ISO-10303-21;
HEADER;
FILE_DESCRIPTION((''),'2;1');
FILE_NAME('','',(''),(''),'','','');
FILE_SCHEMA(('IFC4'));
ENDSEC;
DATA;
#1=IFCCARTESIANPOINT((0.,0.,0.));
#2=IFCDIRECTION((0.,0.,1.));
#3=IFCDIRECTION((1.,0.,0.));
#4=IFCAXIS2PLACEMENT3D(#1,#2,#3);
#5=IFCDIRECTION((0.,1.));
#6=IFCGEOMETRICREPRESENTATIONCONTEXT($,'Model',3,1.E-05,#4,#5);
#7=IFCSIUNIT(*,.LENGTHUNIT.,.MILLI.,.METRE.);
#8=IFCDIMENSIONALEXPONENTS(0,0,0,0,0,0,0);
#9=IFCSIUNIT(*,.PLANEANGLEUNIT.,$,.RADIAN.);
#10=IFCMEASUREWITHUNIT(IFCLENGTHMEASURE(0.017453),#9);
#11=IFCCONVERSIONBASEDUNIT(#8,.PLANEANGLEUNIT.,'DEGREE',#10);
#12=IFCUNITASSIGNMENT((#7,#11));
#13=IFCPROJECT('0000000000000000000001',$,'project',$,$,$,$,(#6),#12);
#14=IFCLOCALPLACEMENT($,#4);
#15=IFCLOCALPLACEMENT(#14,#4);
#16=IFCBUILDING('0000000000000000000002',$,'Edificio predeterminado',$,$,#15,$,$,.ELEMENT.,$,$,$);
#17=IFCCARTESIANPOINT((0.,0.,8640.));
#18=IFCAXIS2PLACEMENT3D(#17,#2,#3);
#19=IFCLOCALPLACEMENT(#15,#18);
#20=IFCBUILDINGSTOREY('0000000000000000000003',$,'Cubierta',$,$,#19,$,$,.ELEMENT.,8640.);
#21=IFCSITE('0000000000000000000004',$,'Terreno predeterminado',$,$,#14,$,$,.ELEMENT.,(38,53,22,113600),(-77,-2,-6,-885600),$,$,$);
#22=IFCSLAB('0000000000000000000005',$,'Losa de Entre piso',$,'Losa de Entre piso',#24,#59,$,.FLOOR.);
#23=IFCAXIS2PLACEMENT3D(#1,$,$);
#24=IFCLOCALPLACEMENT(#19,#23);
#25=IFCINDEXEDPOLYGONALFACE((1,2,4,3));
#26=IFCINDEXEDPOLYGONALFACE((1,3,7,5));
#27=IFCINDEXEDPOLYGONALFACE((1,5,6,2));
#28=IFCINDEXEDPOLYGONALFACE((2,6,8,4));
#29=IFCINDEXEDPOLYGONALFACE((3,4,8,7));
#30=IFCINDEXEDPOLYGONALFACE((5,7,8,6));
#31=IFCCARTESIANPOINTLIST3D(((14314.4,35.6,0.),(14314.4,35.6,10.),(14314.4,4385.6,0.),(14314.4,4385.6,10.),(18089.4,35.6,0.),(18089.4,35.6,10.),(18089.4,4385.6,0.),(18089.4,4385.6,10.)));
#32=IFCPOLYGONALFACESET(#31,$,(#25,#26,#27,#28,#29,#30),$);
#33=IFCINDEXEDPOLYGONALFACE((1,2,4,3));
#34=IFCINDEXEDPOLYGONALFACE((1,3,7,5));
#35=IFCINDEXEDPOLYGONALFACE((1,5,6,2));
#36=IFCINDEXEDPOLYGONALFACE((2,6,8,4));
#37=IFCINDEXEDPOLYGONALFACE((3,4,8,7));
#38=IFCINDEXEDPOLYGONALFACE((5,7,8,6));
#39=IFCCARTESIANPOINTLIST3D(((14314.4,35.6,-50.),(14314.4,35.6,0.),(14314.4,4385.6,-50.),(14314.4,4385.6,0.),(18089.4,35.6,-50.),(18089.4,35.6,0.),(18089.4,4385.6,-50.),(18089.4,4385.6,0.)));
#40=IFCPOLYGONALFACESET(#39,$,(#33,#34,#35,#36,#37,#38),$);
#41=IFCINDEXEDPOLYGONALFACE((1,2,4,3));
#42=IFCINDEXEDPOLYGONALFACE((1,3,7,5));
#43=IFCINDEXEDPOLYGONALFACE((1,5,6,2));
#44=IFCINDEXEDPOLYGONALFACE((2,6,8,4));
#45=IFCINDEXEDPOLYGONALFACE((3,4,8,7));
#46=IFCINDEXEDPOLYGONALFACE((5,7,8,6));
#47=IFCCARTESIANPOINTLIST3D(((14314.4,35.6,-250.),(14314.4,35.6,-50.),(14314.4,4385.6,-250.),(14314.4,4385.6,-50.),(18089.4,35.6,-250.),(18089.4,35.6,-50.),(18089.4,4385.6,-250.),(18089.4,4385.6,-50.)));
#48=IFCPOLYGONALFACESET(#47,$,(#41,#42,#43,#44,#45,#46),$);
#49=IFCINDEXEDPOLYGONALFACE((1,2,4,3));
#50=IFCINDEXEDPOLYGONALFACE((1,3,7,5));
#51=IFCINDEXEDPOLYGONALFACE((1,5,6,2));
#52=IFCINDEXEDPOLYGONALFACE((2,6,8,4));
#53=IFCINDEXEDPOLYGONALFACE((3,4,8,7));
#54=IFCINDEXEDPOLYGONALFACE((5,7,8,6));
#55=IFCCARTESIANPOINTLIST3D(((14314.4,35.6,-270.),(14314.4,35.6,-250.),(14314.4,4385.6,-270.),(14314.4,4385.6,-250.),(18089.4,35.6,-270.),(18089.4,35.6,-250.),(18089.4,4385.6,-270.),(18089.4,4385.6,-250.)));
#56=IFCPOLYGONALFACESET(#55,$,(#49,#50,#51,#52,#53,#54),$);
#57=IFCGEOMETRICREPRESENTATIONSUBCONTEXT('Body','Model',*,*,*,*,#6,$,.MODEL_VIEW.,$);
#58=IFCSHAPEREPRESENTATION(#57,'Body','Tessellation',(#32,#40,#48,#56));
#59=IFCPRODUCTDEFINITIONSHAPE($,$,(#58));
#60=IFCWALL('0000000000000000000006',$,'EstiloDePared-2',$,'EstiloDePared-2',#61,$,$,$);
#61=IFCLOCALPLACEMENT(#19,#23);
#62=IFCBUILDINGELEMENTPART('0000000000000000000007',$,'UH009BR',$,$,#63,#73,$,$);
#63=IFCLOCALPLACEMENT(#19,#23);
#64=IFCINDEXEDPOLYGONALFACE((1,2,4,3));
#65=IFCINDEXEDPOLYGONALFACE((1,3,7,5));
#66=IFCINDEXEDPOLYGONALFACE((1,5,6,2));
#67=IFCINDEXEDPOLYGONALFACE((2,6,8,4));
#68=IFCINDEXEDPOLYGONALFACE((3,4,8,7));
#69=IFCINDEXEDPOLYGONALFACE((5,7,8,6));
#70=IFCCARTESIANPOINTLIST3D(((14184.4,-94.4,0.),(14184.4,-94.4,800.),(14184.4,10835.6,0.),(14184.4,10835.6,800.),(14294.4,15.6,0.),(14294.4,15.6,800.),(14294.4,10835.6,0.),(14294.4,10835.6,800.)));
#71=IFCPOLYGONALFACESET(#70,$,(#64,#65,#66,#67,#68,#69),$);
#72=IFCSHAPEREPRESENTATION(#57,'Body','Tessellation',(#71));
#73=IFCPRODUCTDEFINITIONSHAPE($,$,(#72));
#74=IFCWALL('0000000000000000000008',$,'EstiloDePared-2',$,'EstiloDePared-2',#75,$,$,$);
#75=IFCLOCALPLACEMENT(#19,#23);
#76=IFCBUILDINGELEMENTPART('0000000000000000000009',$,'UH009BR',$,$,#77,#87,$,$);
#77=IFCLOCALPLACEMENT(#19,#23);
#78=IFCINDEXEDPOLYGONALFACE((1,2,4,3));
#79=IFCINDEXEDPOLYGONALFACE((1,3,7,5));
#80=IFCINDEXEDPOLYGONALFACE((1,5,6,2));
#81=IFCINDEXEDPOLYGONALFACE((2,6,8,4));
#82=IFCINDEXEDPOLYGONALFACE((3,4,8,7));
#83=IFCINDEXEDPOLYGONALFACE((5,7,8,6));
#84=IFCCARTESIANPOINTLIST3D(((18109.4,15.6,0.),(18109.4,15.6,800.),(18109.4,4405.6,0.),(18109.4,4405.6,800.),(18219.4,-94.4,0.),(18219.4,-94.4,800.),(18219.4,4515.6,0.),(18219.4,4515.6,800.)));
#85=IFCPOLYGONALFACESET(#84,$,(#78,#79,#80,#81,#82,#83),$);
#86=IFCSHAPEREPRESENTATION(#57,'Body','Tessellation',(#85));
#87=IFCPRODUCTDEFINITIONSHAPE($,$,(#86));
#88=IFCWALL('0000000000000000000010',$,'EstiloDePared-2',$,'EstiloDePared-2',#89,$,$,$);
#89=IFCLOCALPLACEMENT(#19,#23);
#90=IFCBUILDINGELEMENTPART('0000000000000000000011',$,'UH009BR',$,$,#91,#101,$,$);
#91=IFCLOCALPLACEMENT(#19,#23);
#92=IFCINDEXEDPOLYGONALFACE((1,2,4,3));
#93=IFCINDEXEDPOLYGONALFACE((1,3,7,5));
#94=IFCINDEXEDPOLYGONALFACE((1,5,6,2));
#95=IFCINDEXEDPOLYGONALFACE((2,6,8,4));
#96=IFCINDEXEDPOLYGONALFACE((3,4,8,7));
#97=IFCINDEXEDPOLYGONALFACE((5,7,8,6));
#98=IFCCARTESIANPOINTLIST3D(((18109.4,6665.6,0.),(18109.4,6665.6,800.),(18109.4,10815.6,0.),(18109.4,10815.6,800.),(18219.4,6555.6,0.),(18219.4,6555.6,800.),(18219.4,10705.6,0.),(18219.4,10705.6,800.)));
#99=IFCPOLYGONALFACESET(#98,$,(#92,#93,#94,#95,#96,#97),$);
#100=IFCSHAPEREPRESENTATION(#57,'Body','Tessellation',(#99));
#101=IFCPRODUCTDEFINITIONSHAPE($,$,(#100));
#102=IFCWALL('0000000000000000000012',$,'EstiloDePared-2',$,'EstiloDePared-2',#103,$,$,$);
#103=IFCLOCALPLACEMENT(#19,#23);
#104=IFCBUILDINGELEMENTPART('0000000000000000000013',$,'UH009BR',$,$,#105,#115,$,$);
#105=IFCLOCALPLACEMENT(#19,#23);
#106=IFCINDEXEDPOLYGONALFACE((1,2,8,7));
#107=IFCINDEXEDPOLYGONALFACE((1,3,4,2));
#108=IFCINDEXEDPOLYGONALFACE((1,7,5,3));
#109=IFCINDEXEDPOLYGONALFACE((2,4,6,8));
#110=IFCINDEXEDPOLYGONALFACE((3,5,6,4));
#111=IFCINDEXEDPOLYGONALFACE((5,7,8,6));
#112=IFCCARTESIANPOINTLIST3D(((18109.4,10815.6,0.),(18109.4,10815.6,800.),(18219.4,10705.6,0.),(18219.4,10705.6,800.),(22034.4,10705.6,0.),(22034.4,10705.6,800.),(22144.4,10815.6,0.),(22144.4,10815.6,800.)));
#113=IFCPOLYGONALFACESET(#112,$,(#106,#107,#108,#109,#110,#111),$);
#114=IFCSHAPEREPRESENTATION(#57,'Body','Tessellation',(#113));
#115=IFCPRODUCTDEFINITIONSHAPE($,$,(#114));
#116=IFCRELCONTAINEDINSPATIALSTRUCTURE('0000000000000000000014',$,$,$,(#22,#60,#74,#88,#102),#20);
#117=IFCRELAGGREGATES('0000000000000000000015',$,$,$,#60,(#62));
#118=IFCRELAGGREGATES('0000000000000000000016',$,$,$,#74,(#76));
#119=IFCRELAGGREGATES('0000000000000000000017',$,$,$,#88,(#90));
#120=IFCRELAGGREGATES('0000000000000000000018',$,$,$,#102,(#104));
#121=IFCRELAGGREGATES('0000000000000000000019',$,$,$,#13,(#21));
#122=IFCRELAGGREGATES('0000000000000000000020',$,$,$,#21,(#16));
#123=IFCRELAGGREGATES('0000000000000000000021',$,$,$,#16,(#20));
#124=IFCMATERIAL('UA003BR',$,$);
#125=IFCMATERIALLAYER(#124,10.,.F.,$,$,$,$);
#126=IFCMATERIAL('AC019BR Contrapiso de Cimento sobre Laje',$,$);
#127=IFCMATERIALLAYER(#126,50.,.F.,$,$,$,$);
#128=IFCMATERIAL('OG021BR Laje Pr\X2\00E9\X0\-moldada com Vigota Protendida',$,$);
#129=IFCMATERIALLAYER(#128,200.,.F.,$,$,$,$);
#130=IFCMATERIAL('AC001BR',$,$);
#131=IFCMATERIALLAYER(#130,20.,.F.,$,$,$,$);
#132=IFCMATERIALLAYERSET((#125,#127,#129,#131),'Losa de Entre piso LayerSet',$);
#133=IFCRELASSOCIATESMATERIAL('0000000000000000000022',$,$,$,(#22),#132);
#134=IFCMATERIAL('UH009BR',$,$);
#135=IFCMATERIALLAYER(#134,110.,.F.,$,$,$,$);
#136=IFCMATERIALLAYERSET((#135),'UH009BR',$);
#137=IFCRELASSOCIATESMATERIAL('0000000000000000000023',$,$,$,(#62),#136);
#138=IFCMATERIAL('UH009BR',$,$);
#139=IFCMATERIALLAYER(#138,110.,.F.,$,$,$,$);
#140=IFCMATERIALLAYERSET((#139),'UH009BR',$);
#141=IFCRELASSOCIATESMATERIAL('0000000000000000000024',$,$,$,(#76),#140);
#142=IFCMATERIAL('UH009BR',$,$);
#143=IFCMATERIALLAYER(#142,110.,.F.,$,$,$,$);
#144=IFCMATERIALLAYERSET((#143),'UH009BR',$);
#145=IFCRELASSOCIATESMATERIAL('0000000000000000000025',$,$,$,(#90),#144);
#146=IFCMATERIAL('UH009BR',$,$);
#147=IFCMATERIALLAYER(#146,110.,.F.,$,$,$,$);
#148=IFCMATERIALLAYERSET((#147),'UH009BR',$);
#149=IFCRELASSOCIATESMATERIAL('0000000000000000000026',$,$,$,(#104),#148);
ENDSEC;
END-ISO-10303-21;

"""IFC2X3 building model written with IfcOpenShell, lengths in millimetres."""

from ifc_helpers import new_model, entity, si_unit, converted_unit, direction, frame, origin_with_axes, place, context, subcontext, project, spatial, polyline, outline, extrude, material, layer, layer_set, layer_usage, element, aggregate, save


model = new_model("IFC2X3")

# Units and contexts
model_context = context("Model", 3, precision=1e-05, world=origin_with_axes(), true_north=direction((0.0, 1.0)))
body_context = subcontext(model_context, "Body", "Model", "MODEL_VIEW")
ifc_project = project(units=[si_unit("LENGTHUNIT", "METRE", prefix="MILLI"), converted_unit("PLANEANGLEUNIT", "DEGREE", entity("IfcLengthMeasure", 0.017453), si_unit("PLANEANGLEUNIT", "RADIAN"), dimensions=[0, 0, 0, 0, 0, 0, 0])], contexts=[model_context])

# Site, building, storey
site_placement = place(None, origin_with_axes())
site = spatial("IfcSite", under=ifc_project, at=site_placement, Name="Terreno predeterminado", CompositionType="ELEMENT", RefLatitude=(38, 53, 22, 113600), RefLongitude=(-77, -2, -6, -885600))
building_placement = place(site_placement, origin_with_axes())
building = spatial("IfcBuilding", under=site, at=building_placement, Name="Edificio predeterminado", CompositionType="ELEMENT")
storey_placement = place(building_placement, frame((0.0, 0.0, 8640.0), z_axis=(0.0, 0.0, 1.0), x_axis=(1.0, 0.0, 0.0)))
storey = spatial("IfcBuildingStorey", under=building, at=storey_placement, Name="Cubierta", CompositionType="ELEMENT", Elevation=8640.0)

# Slab
ifc_material_1 = material(Name="UA003BR")
ifc_layer_1 = layer(ifc_material_1, 10.0, ventilated=False)
ifc_material_2 = material(Name="AC019BR Contrapiso de Cimento sobre Laje")
ifc_layer_2 = layer(ifc_material_2, 50.0, ventilated=False)
ifc_material_3 = material(Name="OG021BR Laje Pré-moldada com Vigota Protendida")
ifc_layer_3 = layer(ifc_material_3, 200.0, ventilated=False)
ifc_material_4 = material(Name="AC001BR")
ifc_layer_4 = layer(ifc_material_4, 20.0, ventilated=False)
ifc_layer_set_1 = layer_set([ifc_layer_1, ifc_layer_2, ifc_layer_3, ifc_layer_4], Name="Losa de Entre piso LayerSet")
ifc_layer_usage_1 = layer_usage(ifc_layer_set_1, "AXIS3", "NEGATIVE", 0.0)
slab_1_placement = place(storey_placement, frame((0.0, 0.0, -8640.0), z_axis=(0.0, 0.0, 1.0), x_axis=(1.0, 0.0, 0.0)))
element("IfcSlab", 1, at=slab_1_placement, inside=storey, material=ifc_layer_usage_1, Name="Losa de Entre piso", ObjectType="Losa de Entre piso", PredefinedType="FLOOR", context=body_context, shape_type="SweptSolid", body=[
    extrude(outline(polyline([(0.0, 4350.0), (3775.0, 4350.0), (3775.0, 0.0), (0.0, 0.0), (0.0, 4350.0)])), frame((18089.4, 35.6, 8640.0), z_axis=(0.0, 0.0, -1.0), x_axis=(-1.0, 0.0, 0.0)), (0.0, 0.0, -1.0), 10.0),
    extrude(outline(polyline([(0.0, 4350.0), (3775.0, 4350.0), (3775.0, 0.0), (0.0, 0.0), (0.0, 4350.0)])), frame((18089.4, 35.6, 8590.0), z_axis=(0.0, 0.0, -1.0), x_axis=(-1.0, 0.0, 0.0)), (0.0, 0.0, -1.0), 50.0),
    extrude(outline(polyline([(0.0, 4350.0), (3775.0, 4350.0), (3775.0, 0.0), (0.0, 0.0), (0.0, 4350.0)])), frame((18089.4, 35.6, 8390.0), z_axis=(0.0, 0.0, -1.0), x_axis=(-1.0, 0.0, 0.0)), (0.0, 0.0, -1.0), 200.0),
    extrude(outline(polyline([(0.0, 4350.0), (3775.0, 4350.0), (3775.0, 0.0), (0.0, 0.0), (0.0, 4350.0)])), frame((18089.4, 35.6, 8370.0), z_axis=(0.0, 0.0, -1.0), x_axis=(-1.0, 0.0, 0.0)), (0.0, 0.0, -1.0), 20.0),
])

# Walls, building element parts
wall_1_placement = place(storey_placement, frame((14239.4, -39.4, 0.0), z_axis=(0.0, 0.0, 1.0), x_axis=(0.0, 1.0, 0.0)))
wall_1 = element("IfcWall", 2, at=wall_1_placement, inside=storey, Name="EstiloDePared-2", ObjectType="EstiloDePared-2")
ifc_material_5 = material(Name="UH009BR")
ifc_layer_5 = layer(ifc_material_5, 110.0, ventilated=False)
ifc_layer_set_2 = layer_set([ifc_layer_5], Name="UH009BR")
ifc_layer_usage_2 = layer_usage(ifc_layer_set_2, "AXIS2", "NEGATIVE", -55.0)
building_element_part_1_placement = place(wall_1_placement, origin_with_axes())
building_element_part_1 = element("IfcBuildingElementPart", 3, at=building_element_part_1_placement, material=ifc_layer_usage_2, Name="UH009BR", context=body_context, shape_type="SweptSolid", body=[
    extrude(outline(polyline([(10875.0, 55.0), (10875.0, -55.0), (55.0, -55.0), (-55.0, 55.0), (10875.0, 55.0)])), origin_with_axes(), (0.0, 0.0, 1.0), 800.0),
])
aggregate(wall_1, [building_element_part_1])
wall_2_placement = place(storey_placement, frame((18164.4, -39.4, 0.0), z_axis=(0.0, 0.0, 1.0), x_axis=(0.0, 1.0, 0.0)))
wall_2 = element("IfcWall", 4, at=wall_2_placement, inside=storey, Name="EstiloDePared-2", ObjectType="EstiloDePared-2")
ifc_material_6 = material(Name="UH009BR")
ifc_layer_6 = layer(ifc_material_6, 110.0, ventilated=False)
ifc_layer_set_3 = layer_set([ifc_layer_6], Name="UH009BR")
ifc_layer_usage_3 = layer_usage(ifc_layer_set_3, "AXIS2", "NEGATIVE", -55.0)
building_element_part_2_placement = place(wall_2_placement, origin_with_axes())
building_element_part_2 = element("IfcBuildingElementPart", 5, at=building_element_part_2_placement, material=ifc_layer_usage_3, Name="UH009BR", context=body_context, shape_type="SweptSolid", body=[
    extrude(outline(polyline([(4445.0, 55.0), (4555.0, -55.0), (-55.0, -55.0), (55.0, 55.0), (4445.0, 55.0)])), origin_with_axes(), (0.0, 0.0, 1.0), 800.0),
])
aggregate(wall_2, [building_element_part_2])
wall_3_placement = place(storey_placement, frame((18164.4, 6610.6, 0.0), z_axis=(0.0, 0.0, 1.0), x_axis=(0.0, 1.0, 0.0)))
wall_3 = element("IfcWall", 6, at=wall_3_placement, inside=storey, Name="EstiloDePared-2", ObjectType="EstiloDePared-2")
ifc_material_7 = material(Name="UH009BR")
ifc_layer_7 = layer(ifc_material_7, 110.0, ventilated=False)
ifc_layer_set_4 = layer_set([ifc_layer_7], Name="UH009BR")
ifc_layer_usage_4 = layer_usage(ifc_layer_set_4, "AXIS2", "NEGATIVE", -55.0)
building_element_part_3_placement = place(wall_3_placement, origin_with_axes())
building_element_part_3 = element("IfcBuildingElementPart", 7, at=building_element_part_3_placement, material=ifc_layer_usage_4, Name="UH009BR", context=body_context, shape_type="SweptSolid", body=[
    extrude(outline(polyline([(4205.0, 55.0), (4095.0, -55.0), (-55.0, -55.0), (55.0, 55.0), (4205.0, 55.0)])), origin_with_axes(), (0.0, 0.0, 1.0), 800.0),
])
aggregate(wall_3, [building_element_part_3])
wall_4_placement = place(storey_placement, frame((18164.4, 10760.6, 0.0), z_axis=(0.0, 0.0, 1.0), x_axis=(1.0, 0.0, 0.0)))
wall_4 = element("IfcWall", 8, at=wall_4_placement, inside=storey, Name="EstiloDePared-2", ObjectType="EstiloDePared-2")
ifc_material_8 = material(Name="UH009BR")
ifc_layer_8 = layer(ifc_material_8, 110.0, ventilated=False)
ifc_layer_set_5 = layer_set([ifc_layer_8], Name="UH009BR")
ifc_layer_usage_5 = layer_usage(ifc_layer_set_5, "AXIS2", "NEGATIVE", -55.0)
building_element_part_4_placement = place(wall_4_placement, origin_with_axes())
building_element_part_4 = element("IfcBuildingElementPart", 9, at=building_element_part_4_placement, material=ifc_layer_usage_5, Name="UH009BR", context=body_context, shape_type="SweptSolid", body=[
    extrude(outline(polyline([(3980.0, 55.0), (3870.0, -55.0), (55.0, -55.0), (-55.0, 55.0), (3980.0, 55.0)])), origin_with_axes(), (0.0, 0.0, 1.0), 800.0),
])
aggregate(wall_4, [building_element_part_4])

save(model, "model.ifc")
